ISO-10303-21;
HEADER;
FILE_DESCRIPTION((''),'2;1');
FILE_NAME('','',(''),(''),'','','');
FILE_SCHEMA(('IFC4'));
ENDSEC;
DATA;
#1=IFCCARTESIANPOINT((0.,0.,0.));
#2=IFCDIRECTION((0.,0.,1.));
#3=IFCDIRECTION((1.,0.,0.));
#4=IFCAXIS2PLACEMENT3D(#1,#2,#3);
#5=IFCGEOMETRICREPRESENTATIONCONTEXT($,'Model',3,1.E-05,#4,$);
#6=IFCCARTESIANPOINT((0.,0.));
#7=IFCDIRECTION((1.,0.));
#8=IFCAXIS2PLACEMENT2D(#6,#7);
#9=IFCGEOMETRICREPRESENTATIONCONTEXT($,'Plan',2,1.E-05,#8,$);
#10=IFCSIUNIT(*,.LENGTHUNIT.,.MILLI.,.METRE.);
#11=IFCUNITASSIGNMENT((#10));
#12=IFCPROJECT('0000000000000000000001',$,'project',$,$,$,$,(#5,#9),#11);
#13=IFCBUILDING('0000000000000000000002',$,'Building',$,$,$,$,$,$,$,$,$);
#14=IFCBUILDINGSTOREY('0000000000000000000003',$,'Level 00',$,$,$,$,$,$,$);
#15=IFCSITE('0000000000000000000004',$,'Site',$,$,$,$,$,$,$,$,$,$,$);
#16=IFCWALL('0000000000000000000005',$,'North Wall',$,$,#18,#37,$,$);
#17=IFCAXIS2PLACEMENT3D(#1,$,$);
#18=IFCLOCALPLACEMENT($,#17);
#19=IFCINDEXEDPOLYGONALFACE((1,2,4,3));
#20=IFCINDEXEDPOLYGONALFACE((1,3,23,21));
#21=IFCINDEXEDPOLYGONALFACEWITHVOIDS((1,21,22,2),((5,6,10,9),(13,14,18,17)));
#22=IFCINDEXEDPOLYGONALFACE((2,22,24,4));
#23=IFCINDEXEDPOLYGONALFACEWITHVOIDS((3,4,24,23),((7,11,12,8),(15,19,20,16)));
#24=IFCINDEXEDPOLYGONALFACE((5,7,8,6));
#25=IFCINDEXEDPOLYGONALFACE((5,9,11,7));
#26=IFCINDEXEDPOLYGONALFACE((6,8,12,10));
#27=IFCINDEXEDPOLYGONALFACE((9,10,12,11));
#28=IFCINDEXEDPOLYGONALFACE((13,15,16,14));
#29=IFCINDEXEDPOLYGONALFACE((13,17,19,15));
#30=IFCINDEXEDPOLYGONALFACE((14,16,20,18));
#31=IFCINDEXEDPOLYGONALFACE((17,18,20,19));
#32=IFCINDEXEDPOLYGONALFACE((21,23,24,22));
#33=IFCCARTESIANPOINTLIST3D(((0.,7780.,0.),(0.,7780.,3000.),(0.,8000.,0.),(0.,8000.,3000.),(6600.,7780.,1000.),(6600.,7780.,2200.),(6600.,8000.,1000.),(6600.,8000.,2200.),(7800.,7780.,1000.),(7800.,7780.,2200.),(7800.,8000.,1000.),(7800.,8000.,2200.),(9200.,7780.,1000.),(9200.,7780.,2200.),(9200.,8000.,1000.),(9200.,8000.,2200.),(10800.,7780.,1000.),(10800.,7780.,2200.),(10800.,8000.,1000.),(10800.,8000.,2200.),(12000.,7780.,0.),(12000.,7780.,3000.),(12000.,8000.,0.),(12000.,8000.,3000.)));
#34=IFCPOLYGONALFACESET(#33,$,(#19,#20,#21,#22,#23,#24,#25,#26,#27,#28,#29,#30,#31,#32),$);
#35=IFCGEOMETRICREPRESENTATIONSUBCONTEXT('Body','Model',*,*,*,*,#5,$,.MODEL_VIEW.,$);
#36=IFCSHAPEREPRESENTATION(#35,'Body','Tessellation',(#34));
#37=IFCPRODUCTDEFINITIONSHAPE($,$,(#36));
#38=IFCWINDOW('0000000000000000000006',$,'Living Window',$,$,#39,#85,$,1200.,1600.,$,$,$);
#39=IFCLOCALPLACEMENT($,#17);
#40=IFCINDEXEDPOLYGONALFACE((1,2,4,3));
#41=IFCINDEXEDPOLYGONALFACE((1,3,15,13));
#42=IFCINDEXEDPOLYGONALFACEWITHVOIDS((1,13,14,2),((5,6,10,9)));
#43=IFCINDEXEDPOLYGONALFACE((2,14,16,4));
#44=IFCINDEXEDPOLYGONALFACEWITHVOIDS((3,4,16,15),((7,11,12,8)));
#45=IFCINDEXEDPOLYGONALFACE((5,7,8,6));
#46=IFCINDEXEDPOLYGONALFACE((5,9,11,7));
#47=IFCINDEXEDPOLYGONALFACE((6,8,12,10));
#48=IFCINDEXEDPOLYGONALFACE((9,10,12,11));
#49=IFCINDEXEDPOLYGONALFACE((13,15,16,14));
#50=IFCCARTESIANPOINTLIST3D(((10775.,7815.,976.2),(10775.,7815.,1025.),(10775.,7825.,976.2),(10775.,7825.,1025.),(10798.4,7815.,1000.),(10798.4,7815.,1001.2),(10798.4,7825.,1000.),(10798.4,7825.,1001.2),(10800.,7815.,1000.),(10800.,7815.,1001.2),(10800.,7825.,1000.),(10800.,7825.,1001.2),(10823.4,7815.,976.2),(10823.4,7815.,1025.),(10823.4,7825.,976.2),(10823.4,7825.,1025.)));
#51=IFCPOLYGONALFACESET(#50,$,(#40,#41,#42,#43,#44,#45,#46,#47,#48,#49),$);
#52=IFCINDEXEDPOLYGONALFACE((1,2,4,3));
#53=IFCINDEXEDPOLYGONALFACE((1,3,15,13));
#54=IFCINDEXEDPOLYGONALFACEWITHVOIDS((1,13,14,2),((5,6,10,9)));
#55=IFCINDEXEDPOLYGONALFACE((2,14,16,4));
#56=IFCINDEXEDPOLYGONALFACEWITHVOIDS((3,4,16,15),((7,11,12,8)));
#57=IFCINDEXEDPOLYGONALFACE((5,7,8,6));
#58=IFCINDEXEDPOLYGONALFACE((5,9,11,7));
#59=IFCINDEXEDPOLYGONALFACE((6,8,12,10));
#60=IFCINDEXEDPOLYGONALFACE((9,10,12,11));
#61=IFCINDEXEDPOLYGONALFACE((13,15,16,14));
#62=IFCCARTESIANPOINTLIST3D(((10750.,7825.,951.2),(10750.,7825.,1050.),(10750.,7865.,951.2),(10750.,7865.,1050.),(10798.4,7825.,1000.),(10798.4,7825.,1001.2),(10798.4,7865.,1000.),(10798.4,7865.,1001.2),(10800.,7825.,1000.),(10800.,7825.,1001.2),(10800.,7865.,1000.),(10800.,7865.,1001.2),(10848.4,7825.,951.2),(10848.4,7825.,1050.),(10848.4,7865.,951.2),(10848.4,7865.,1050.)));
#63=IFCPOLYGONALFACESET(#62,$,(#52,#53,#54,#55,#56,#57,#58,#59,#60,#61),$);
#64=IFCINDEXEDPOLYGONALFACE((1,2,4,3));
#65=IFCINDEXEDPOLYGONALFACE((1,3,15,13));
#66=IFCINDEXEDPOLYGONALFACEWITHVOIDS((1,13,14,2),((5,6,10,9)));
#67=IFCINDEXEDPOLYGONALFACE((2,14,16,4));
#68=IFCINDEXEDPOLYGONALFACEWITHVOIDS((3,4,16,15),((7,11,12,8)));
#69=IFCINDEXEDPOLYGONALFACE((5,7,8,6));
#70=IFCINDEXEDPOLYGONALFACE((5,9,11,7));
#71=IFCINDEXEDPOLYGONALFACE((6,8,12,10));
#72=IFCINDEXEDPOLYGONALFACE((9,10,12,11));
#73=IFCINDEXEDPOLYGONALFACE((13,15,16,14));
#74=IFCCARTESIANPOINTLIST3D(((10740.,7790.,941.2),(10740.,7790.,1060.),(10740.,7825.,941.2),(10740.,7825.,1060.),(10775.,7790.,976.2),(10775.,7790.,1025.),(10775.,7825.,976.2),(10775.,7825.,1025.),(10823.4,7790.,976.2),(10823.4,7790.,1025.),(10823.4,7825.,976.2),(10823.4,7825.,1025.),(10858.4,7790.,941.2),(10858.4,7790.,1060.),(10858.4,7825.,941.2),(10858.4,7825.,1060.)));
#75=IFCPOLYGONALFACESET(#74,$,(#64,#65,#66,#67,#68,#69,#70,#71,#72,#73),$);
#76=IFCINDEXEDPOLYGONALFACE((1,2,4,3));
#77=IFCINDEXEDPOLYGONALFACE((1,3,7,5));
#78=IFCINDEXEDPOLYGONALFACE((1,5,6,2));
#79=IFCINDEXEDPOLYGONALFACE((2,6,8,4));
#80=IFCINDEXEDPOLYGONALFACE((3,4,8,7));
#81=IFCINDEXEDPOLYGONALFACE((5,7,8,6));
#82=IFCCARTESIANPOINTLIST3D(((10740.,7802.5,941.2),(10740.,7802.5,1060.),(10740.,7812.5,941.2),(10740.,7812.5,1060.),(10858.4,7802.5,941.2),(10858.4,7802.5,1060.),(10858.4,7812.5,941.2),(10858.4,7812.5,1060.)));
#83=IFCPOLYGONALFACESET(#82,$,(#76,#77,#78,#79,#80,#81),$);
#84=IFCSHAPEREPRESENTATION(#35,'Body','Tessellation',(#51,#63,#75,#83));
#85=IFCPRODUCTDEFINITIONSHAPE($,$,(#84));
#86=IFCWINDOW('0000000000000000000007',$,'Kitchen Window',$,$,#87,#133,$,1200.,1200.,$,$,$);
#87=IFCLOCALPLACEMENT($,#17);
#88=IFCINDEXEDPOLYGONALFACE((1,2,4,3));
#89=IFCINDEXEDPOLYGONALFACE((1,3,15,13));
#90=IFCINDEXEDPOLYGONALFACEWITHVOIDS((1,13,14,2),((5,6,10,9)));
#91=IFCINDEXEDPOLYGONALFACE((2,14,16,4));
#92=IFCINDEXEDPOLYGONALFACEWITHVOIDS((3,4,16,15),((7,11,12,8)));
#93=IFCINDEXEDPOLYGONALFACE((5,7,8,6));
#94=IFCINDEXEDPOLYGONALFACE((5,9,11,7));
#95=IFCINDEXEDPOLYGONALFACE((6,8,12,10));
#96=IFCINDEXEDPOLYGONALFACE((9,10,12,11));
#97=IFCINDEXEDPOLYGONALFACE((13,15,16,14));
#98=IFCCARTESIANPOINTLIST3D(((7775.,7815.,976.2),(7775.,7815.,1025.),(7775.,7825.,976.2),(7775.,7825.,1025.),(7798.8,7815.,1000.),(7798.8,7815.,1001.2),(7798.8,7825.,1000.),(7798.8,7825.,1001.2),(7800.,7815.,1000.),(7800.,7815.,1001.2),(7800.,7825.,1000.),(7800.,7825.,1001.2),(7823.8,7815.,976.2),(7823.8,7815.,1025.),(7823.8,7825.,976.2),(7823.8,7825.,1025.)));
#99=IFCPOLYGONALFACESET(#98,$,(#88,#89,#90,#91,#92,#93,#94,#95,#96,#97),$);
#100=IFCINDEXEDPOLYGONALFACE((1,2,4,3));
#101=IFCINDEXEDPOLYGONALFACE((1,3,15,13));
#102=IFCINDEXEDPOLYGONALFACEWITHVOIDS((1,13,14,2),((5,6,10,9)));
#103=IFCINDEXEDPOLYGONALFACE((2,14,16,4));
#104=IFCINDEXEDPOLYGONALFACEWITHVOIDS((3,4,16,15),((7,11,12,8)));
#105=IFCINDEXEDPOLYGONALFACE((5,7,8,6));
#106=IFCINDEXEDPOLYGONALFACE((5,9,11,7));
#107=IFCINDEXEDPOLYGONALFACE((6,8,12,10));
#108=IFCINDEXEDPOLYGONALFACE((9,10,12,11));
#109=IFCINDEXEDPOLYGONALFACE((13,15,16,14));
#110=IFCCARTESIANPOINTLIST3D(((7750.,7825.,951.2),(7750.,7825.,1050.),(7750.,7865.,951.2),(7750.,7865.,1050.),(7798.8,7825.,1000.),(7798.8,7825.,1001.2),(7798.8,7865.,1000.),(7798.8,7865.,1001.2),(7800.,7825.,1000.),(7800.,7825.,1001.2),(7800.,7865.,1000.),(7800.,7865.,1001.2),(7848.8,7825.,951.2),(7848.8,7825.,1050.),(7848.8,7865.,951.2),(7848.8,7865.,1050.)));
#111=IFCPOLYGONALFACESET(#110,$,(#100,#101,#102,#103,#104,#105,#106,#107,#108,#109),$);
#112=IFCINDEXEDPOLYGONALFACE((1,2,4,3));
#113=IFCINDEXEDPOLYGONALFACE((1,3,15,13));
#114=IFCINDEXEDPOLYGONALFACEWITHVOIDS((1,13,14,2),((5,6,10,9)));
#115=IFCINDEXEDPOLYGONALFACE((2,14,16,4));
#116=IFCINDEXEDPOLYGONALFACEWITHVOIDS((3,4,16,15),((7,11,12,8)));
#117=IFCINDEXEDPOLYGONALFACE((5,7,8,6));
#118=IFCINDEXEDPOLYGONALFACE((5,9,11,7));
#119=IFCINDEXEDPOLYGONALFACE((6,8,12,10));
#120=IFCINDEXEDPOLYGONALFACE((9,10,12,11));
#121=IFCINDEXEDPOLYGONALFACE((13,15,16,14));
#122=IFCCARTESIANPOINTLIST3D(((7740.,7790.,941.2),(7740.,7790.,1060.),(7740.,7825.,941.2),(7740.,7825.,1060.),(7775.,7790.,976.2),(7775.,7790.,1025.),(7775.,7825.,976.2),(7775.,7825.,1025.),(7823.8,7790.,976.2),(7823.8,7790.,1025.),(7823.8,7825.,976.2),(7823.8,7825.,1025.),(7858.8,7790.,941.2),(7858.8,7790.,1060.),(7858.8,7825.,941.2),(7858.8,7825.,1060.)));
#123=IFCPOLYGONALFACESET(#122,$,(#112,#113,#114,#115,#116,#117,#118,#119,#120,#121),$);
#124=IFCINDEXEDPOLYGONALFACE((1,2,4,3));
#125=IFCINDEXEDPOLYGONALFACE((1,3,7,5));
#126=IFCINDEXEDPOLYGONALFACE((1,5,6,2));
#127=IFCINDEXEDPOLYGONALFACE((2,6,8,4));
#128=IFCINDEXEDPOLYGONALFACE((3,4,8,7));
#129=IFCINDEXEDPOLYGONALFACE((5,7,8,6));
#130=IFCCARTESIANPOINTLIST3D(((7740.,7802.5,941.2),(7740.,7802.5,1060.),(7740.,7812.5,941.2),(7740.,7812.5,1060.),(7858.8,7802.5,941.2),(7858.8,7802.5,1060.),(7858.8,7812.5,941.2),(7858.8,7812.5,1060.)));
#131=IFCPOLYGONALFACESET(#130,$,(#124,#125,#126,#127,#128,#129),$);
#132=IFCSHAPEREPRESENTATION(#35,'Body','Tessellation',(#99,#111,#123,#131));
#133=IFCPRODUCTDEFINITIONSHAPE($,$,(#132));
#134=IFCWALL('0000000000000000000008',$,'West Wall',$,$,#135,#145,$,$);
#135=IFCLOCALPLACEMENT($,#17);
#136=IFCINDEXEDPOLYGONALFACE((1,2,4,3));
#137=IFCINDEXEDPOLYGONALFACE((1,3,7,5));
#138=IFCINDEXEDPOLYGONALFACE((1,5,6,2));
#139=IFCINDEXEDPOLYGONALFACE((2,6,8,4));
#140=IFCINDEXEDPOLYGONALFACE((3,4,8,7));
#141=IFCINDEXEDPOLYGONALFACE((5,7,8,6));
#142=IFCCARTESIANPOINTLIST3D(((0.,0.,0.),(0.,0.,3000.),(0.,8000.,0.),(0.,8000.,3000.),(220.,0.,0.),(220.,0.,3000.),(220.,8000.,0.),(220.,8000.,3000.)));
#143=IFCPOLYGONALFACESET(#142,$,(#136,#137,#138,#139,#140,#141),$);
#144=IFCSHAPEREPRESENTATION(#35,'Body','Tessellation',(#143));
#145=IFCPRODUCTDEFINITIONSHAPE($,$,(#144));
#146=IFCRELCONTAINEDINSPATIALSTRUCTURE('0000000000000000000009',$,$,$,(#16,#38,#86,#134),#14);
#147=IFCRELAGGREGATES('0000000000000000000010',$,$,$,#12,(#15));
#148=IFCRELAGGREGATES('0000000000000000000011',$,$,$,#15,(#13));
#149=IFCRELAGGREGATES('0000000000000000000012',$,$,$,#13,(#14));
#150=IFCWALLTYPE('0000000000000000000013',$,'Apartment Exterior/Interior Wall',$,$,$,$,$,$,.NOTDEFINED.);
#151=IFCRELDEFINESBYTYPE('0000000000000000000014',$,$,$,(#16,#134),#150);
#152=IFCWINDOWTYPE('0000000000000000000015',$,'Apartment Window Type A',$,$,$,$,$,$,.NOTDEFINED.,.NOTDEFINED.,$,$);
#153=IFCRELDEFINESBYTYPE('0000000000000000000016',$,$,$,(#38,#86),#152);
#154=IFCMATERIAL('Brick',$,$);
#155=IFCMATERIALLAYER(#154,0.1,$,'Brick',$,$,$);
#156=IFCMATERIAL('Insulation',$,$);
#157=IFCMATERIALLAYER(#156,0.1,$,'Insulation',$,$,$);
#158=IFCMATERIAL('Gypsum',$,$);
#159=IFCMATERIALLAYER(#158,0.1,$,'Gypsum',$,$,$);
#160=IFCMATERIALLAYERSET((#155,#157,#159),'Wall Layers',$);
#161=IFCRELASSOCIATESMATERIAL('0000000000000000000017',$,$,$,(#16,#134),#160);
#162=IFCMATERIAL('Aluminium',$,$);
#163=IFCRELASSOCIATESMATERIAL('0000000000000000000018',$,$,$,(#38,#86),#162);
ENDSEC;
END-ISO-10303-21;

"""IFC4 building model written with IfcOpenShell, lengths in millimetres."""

from ifc_helpers import new_model, si_unit, frame, origin_with_axes, origin_2d_with_axis, place, context, subcontext, project, spatial, line, indexed_curve, outline, extrude, material, layer, layer_set, layer_usage, type_object, element, fill, save


model = new_model("IFC4")

# Units and contexts
model_context = context("Model", 3, precision=1e-05, world=origin_with_axes())
plan_context = context("Plan", 2, precision=1e-05, world=origin_2d_with_axis())
body_context = subcontext(model_context, "Body", "Model", "MODEL_VIEW")
ifc_project = project(units=[si_unit("LENGTHUNIT", "METRE", prefix="MILLI")], contexts=[model_context, plan_context])

# Site, building, storey
site = spatial("IfcSite", under=ifc_project, Name="Site")
building = spatial("IfcBuilding", under=site, Name="Building")
storey = spatial("IfcBuildingStorey", under=building, Name="Level 00")

# Shared definitions
ifc_material_1 = material(Name="Brick")
ifc_layer_1 = layer(ifc_material_1, 0.1, Name="Brick")
ifc_material_2 = material(Name="Insulation")
ifc_layer_2 = layer(ifc_material_2, 0.1, Name="Insulation")
ifc_material_3 = material(Name="Gypsum")
ifc_layer_3 = layer(ifc_material_3, 0.1, Name="Gypsum")
ifc_layer_set = layer_set([ifc_layer_1, ifc_layer_2, ifc_layer_3], Name="Wall Layers")
ifc_layer_usage = layer_usage(ifc_layer_set, "AXIS2", "POSITIVE", 0.0)
wall_type = type_object("IfcWallType", Name="Apartment Exterior/Interior Wall", PredefinedType="NOTDEFINED")

# Wall, openings, windows
ifc_material_4 = material(Name="Aluminium")
window_type = type_object("IfcWindowType", Name="Apartment Window Type A", PartitioningType="NOTDEFINED", PredefinedType="NOTDEFINED")
wall_1_placement = place(None, frame((12000.0, 8000.0, 0.0), z_axis=(0.0, 0.0, 1.0), x_axis=(-1.0, 0.0, 0.0)))
wall_1 = element("IfcWall", 1, at=wall_1_placement, inside=storey, type_object=wall_type, material=ifc_layer_usage, Name="North Wall", context=body_context, shape_type="SweptSolid", body=[
    extrude(outline(indexed_curve([(0.0, 0.0), (0.0, 220.0), (12000.0, 220.0), (12000.0, 0.0), (0.0, 0.0)], self_intersect=False)), origin_with_axes(), (0.0, 0.0, 1.0), 3000.0),
])
opening_1_placement = place(wall_1_placement, frame((1200.0, -22.0, 1000.0), z_axis=(0.0, 0.0, 1.0), x_axis=(1.0, 0.0, 0.0)))
opening_1 = element("IfcOpeningElement", 2, at=opening_1_placement, cuts=wall_1, context=body_context, shape_type="SweptSolid", body=[
    extrude(outline(indexed_curve([(0.0, 0.0), (0.0, 264.0), (1600.0, 264.0), (1600.0, 0.0), (0.0, 0.0)], self_intersect=False)), origin_with_axes(), (0.0, 0.0, 1.0), 1200.0),
])
opening_2_placement = place(wall_1_placement, frame((4200.0, -22.0, 1000.0), z_axis=(0.0, 0.0, 1.0), x_axis=(1.0, 0.0, 0.0)))
opening_2 = element("IfcOpeningElement", 3, at=opening_2_placement, cuts=wall_1, context=body_context, shape_type="SweptSolid", body=[
    extrude(outline(indexed_curve([(0.0, 0.0), (0.0, 264.0), (1200.0, 264.0), (1200.0, 0.0), (0.0, 0.0)], self_intersect=False)), origin_with_axes(), (0.0, 0.0, 1.0), 1200.0),
])
window_1_placement = place(opening_1_placement, frame((0.0, 107.0, 0.0), z_axis=(0.0, 0.0, 1.0), x_axis=(1.0, 0.0, 0.0)))
window_1 = element("IfcWindow", 4, at=window_1_placement, inside=storey, type_object=window_type, material=ifc_material_4, Name="Living Window", OverallHeight=1200.0, OverallWidth=1600.0, context=body_context, shape_type="SweptSolid", body=[
    extrude(outline(indexed_curve([(0.0, 0.0), (1.6, 0.0), (1.6, 1.2), (0.0, 1.2)], segments=[line(1, 2, 3, 4, 1)]), holes=[indexed_curve([(25.0, 25.0), (-23.4, 25.0), (-23.4, -23.8), (25.0, -23.8)], segments=[line(1, 2, 3, 4, 1)])]), frame((0.0, 90.0, 0.0), z_axis=(0.0, -1.0, 0.0), x_axis=(1.0, 0.0, 0.0)), (0.0, 0.0, -1.0), 10.0),
    extrude(outline(indexed_curve([(0.0, 0.0), (1.6, 0.0), (1.6, 1.2), (0.0, 1.2)], segments=[line(1, 2, 3, 4, 1)]), holes=[indexed_curve([(50.0, 50.0), (-48.4, 50.0), (-48.4, -48.8), (50.0, -48.8)], segments=[line(1, 2, 3, 4, 1)])]), frame((0.0, 50.0, 0.0), z_axis=(0.0, -1.0, 0.0), x_axis=(1.0, 0.0, 0.0)), (0.0, 0.0, -1.0), 40.0),
    extrude(outline(indexed_curve([(0.0, 0.0), (-48.4, 0.0), (-48.4, -48.8), (0.0, -48.8)], segments=[line(1, 2, 3, 4, 1)]), holes=[indexed_curve([(35.0, 35.0), (-83.4, 35.0), (-83.4, -83.8), (35.0, -83.8)], segments=[line(1, 2, 3, 4, 1)])]), frame((25.0, 90.0, 25.0), z_axis=(0.0, -1.0, 0.0), x_axis=(1.0, 0.0, 0.0)), (0.0, 0.0, -1.0), 35.0),
    extrude(outline(indexed_curve([(35.0, 35.0), (-83.4, 35.0), (-83.4, -83.8), (35.0, -83.8)], segments=[line(1, 2, 3, 4, 1)])), frame((25.0, 102.5, 25.0), z_axis=(0.0, -1.0, 0.0), x_axis=(1.0, 0.0, 0.0)), (0.0, 0.0, -1.0), 10.0),
])
fill(opening_1, window_1)
window_2_placement = place(opening_2_placement, frame((0.0, 107.0, 0.0), z_axis=(0.0, 0.0, 1.0), x_axis=(1.0, 0.0, 0.0)))
window_2 = element("IfcWindow", 5, at=window_2_placement, inside=storey, type_object=window_type, material=ifc_material_4, Name="Kitchen Window", OverallHeight=1200.0, OverallWidth=1200.0, context=body_context, shape_type="SweptSolid", body=[
    extrude(outline(indexed_curve([(0.0, 0.0), (1.2, 0.0), (1.2, 1.2), (0.0, 1.2)], segments=[line(1, 2, 3, 4, 1)]), holes=[indexed_curve([(25.0, 25.0), (-23.8, 25.0), (-23.8, -23.8), (25.0, -23.8)], segments=[line(1, 2, 3, 4, 1)])]), frame((0.0, 90.0, 0.0), z_axis=(0.0, -1.0, 0.0), x_axis=(1.0, 0.0, 0.0)), (0.0, 0.0, -1.0), 10.0),
    extrude(outline(indexed_curve([(0.0, 0.0), (1.2, 0.0), (1.2, 1.2), (0.0, 1.2)], segments=[line(1, 2, 3, 4, 1)]), holes=[indexed_curve([(50.0, 50.0), (-48.8, 50.0), (-48.8, -48.8), (50.0, -48.8)], segments=[line(1, 2, 3, 4, 1)])]), frame((0.0, 50.0, 0.0), z_axis=(0.0, -1.0, 0.0), x_axis=(1.0, 0.0, 0.0)), (0.0, 0.0, -1.0), 40.0),
    extrude(outline(indexed_curve([(0.0, 0.0), (-48.8, 0.0), (-48.8, -48.8), (0.0, -48.8)], segments=[line(1, 2, 3, 4, 1)]), holes=[indexed_curve([(35.0, 35.0), (-83.8, 35.0), (-83.8, -83.8), (35.0, -83.8)], segments=[line(1, 2, 3, 4, 1)])]), frame((25.0, 90.0, 25.0), z_axis=(0.0, -1.0, 0.0), x_axis=(1.0, 0.0, 0.0)), (0.0, 0.0, -1.0), 35.0),
    extrude(outline(indexed_curve([(35.0, 35.0), (-83.8, 35.0), (-83.8, -83.8), (35.0, -83.8)], segments=[line(1, 2, 3, 4, 1)])), frame((25.0, 102.5, 25.0), z_axis=(0.0, -1.0, 0.0), x_axis=(1.0, 0.0, 0.0)), (0.0, 0.0, -1.0), 10.0),
])
fill(opening_2, window_2)

# Wall
wall_2_placement = place(None, frame((0.0, 8000.0, 0.0), z_axis=(0.0, 0.0, 1.0), x_axis=(0.0, -1.0, 0.0)))
element("IfcWall", 6, at=wall_2_placement, inside=storey, type_object=wall_type, material=ifc_layer_usage, Name="West Wall", context=body_context, shape_type="SweptSolid", body=[
    extrude(outline(indexed_curve([(0.0, 0.0), (0.0, 220.0), (8000.0, 220.0), (8000.0, 0.0), (0.0, 0.0)], self_intersect=False)), origin_with_axes(), (0.0, 0.0, 1.0), 3000.0),
])

save(model, "model.ifc")
